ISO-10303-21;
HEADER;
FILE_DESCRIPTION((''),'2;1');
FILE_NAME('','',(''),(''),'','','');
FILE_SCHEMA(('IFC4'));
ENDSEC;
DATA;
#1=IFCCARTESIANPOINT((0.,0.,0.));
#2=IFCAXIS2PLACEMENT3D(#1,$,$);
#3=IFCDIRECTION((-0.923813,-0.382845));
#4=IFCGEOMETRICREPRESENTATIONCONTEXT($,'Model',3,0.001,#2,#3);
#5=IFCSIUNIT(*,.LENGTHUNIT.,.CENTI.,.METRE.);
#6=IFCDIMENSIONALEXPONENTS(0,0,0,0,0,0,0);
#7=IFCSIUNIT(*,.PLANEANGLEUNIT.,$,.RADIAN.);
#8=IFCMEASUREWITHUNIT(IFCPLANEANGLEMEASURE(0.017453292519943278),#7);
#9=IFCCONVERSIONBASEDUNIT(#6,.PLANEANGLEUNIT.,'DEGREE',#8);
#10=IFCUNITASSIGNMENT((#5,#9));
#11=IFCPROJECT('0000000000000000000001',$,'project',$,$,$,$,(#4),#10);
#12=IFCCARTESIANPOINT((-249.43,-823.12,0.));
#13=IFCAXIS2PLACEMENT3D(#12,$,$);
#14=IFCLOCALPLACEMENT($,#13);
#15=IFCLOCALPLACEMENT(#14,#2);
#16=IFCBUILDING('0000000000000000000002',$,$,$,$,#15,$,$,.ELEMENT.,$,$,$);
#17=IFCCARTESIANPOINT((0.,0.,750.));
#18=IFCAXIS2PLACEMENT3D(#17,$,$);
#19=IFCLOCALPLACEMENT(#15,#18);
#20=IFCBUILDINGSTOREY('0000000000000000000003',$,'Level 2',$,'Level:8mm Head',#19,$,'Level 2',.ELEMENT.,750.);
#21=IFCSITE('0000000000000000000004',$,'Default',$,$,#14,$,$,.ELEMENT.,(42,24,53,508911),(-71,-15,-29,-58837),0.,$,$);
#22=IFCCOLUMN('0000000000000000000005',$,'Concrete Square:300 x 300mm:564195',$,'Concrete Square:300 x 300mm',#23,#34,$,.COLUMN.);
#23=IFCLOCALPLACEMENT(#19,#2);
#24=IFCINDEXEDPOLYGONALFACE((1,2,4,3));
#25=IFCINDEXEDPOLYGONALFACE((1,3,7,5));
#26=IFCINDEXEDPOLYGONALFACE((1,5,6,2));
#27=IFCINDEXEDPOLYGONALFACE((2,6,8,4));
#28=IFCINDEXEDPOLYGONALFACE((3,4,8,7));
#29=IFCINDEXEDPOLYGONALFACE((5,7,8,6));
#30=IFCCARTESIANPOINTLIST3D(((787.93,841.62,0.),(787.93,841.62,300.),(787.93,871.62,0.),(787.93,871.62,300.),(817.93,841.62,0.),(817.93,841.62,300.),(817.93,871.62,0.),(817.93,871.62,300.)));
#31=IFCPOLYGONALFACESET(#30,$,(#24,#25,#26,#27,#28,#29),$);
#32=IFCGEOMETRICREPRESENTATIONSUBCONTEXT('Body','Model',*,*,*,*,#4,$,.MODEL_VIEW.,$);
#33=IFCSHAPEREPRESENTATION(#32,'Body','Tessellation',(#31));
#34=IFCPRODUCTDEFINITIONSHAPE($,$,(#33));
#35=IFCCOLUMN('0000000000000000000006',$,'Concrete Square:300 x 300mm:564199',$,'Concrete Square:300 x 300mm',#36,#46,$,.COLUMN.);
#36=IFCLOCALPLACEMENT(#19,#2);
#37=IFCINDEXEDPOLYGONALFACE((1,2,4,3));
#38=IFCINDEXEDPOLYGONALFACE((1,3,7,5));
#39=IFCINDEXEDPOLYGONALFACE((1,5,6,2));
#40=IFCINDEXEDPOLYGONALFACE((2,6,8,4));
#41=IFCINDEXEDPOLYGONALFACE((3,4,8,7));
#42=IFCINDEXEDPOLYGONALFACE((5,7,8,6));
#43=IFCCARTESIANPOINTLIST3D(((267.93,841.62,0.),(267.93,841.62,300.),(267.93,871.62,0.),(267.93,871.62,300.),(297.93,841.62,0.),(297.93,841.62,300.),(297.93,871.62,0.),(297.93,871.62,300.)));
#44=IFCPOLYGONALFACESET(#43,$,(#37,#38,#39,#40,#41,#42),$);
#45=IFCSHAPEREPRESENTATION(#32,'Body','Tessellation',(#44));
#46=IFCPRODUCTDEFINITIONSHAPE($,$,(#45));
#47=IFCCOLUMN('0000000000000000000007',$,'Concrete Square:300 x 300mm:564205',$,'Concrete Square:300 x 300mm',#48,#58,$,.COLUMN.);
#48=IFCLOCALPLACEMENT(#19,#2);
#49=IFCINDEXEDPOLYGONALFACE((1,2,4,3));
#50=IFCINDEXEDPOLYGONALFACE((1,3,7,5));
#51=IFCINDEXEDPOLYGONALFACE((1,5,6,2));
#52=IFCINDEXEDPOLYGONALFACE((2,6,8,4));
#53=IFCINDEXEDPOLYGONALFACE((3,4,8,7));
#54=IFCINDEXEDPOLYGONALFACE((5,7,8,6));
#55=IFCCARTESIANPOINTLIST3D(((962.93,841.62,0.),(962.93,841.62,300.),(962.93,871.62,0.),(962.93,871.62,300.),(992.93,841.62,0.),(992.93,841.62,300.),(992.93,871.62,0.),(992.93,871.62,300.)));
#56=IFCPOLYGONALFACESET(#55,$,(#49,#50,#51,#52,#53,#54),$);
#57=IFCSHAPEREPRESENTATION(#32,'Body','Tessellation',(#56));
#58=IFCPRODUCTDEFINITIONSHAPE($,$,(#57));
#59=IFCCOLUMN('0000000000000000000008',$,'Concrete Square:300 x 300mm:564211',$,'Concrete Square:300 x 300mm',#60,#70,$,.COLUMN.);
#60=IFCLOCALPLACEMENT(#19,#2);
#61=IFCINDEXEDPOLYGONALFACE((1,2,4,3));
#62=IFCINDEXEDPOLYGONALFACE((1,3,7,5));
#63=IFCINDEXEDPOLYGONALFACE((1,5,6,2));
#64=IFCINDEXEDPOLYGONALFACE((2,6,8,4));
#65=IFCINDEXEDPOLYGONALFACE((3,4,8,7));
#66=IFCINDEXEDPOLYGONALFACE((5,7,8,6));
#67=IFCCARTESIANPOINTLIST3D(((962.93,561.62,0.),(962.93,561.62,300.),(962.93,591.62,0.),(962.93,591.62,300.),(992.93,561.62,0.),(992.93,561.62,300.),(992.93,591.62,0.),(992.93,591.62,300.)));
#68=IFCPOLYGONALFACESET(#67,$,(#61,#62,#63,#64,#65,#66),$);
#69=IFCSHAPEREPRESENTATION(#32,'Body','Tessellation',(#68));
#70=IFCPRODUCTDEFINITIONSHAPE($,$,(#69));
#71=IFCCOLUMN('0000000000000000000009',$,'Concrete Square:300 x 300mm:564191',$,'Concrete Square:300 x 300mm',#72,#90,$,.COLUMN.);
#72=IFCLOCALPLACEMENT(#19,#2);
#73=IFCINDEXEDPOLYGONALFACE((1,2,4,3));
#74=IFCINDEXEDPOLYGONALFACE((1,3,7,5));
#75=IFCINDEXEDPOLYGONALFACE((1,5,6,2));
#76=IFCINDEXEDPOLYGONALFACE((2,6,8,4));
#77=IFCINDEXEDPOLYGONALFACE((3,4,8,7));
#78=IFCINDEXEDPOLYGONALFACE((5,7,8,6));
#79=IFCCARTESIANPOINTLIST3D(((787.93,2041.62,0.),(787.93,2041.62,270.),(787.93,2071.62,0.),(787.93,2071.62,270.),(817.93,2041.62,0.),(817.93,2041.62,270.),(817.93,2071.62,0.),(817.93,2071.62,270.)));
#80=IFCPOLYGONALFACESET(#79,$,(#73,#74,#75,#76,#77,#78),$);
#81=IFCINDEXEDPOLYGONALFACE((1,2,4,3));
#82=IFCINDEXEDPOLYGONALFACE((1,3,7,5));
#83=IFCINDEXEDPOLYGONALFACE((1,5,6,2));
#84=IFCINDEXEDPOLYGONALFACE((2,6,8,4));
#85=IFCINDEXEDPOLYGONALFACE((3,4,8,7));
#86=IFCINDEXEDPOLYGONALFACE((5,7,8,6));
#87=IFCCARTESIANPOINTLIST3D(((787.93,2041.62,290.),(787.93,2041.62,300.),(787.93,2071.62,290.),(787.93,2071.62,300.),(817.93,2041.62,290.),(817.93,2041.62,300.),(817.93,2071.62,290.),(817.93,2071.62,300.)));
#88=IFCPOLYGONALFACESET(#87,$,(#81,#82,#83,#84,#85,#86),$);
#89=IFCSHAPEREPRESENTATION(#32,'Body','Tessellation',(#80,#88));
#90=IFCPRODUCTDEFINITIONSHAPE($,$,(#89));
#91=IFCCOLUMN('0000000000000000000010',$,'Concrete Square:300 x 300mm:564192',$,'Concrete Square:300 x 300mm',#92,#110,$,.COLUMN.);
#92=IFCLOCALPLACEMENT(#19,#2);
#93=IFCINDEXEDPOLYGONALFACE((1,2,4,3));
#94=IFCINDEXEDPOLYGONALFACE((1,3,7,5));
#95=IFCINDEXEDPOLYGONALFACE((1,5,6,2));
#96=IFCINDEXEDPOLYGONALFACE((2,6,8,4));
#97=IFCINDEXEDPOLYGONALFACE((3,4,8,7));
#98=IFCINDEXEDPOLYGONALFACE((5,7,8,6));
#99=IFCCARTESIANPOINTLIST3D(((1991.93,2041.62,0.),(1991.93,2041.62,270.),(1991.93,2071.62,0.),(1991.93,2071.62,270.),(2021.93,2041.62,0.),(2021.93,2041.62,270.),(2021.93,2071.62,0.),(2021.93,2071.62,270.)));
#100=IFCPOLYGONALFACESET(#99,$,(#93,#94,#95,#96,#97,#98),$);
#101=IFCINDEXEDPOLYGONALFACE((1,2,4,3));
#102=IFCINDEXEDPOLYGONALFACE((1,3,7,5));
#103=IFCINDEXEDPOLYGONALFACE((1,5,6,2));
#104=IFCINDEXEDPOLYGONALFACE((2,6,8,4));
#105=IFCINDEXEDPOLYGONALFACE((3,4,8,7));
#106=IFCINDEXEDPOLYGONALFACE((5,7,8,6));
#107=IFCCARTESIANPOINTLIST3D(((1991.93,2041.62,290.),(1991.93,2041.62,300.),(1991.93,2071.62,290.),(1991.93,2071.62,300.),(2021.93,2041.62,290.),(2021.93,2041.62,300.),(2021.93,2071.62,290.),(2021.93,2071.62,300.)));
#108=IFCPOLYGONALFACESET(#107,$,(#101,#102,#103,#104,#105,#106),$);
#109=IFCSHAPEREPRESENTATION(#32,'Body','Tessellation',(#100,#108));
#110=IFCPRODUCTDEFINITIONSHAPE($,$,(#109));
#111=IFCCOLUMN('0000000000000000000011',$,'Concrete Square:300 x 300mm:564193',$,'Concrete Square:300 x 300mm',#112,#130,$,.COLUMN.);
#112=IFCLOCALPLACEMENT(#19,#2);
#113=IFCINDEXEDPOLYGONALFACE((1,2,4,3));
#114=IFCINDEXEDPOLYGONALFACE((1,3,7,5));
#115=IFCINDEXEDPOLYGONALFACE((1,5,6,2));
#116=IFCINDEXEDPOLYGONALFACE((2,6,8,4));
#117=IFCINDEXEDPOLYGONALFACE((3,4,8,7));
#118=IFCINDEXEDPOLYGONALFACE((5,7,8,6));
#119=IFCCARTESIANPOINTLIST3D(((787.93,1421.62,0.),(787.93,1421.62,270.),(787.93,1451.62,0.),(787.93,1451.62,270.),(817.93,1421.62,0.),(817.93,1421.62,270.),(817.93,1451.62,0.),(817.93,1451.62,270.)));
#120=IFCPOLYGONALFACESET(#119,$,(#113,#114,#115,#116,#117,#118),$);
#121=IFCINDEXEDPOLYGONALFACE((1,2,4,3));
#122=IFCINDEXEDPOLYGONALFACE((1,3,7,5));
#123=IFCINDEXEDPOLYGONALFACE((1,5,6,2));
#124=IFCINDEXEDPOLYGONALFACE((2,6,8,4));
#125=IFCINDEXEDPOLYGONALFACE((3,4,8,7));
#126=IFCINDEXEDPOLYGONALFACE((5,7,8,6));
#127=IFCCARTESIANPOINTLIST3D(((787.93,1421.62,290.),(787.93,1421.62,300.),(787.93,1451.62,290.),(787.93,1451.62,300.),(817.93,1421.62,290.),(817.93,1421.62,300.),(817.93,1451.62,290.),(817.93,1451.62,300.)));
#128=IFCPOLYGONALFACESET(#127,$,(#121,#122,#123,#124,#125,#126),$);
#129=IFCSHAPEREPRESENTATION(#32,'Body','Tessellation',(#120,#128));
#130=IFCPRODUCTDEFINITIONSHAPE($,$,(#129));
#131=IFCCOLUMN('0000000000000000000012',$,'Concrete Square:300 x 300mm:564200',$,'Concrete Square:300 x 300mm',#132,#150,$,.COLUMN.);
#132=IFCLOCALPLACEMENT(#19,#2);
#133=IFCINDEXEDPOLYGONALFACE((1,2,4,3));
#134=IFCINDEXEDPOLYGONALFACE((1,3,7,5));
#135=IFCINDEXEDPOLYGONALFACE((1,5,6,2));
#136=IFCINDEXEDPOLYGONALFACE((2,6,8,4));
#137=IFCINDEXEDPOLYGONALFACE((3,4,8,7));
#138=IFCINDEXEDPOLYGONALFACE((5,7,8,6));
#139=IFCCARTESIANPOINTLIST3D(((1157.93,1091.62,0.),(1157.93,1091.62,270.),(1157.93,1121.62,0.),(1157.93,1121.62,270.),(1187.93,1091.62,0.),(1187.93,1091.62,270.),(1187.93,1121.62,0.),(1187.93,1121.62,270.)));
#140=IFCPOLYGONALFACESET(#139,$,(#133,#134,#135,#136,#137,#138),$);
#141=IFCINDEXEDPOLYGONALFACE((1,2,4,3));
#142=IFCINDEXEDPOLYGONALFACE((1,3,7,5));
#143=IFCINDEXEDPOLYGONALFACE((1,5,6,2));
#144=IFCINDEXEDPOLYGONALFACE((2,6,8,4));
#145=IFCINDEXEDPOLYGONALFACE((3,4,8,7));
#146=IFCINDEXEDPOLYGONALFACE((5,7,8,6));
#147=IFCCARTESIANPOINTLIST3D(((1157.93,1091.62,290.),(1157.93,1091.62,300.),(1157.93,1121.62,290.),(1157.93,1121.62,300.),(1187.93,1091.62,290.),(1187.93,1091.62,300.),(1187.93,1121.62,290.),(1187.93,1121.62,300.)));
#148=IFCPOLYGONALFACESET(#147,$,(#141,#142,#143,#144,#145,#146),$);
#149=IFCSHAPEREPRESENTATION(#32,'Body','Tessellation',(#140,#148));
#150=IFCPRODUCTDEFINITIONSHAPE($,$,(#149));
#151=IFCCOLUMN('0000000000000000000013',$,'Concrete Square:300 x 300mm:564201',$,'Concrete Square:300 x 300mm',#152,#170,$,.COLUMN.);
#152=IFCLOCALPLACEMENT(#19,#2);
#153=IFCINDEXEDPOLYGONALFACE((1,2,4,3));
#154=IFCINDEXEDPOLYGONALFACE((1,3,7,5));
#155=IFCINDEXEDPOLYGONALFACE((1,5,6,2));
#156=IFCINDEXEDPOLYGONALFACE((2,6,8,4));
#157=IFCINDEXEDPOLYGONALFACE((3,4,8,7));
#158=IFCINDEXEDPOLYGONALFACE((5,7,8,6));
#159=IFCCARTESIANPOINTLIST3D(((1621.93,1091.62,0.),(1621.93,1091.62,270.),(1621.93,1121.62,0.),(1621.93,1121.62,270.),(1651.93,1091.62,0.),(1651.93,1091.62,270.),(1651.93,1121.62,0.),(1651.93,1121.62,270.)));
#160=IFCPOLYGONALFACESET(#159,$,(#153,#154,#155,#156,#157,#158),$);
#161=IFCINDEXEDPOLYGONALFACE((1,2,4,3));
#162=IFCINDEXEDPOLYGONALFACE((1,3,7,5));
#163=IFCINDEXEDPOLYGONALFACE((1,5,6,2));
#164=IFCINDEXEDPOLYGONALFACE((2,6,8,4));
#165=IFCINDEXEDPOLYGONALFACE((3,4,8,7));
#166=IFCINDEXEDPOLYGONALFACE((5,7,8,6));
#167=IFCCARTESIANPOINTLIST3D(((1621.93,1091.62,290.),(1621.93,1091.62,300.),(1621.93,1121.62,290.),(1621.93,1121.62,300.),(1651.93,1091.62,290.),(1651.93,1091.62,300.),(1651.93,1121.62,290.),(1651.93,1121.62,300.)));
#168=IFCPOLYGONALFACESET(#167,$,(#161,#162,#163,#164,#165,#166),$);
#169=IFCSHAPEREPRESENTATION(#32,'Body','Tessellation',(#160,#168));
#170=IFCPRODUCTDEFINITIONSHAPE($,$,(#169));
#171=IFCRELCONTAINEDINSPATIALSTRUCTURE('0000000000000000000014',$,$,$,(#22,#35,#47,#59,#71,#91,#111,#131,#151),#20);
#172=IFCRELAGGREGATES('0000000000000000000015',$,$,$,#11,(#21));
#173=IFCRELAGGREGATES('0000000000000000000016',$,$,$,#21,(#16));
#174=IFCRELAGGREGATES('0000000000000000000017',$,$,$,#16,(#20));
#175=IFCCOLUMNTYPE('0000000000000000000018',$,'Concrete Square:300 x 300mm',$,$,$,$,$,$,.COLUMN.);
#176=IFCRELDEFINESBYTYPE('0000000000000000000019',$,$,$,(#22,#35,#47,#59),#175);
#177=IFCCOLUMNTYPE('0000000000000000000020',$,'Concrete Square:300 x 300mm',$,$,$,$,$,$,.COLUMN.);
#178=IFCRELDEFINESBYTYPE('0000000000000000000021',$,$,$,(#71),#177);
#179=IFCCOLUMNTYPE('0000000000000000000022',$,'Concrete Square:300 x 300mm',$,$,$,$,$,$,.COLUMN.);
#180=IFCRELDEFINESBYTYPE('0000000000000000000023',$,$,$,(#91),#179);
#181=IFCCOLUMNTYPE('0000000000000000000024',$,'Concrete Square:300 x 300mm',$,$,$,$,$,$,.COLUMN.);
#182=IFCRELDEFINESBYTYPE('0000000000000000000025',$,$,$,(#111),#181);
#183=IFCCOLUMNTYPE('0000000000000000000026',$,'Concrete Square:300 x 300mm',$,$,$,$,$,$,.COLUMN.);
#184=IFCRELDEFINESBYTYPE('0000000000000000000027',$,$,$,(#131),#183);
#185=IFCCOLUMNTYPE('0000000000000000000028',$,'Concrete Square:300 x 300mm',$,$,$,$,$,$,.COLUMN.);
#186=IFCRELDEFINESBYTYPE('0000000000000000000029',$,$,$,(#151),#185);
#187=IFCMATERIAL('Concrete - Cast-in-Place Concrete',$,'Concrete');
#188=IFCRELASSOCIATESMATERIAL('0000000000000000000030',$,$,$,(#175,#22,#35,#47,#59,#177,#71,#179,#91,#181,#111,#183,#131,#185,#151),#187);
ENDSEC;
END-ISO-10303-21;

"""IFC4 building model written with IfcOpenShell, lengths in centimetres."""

from ifc_helpers import new_model, entity, si_unit, converted_unit, direction, frame, origin, place, context, subcontext, project, spatial, indexed_curve, outline, extrude, source, transform, mapped, material, type_object, type_shapes, element, save


model = new_model("IFC4")

# Units and contexts
model_context = context("Model", 3, precision=0.001, world=origin(), true_north=direction((-0.923813, -0.382845)))
body_context = subcontext(model_context, "Body", "Model", "MODEL_VIEW")
ifc_project = project(units=[si_unit("LENGTHUNIT", "METRE", prefix="CENTI"), converted_unit("PLANEANGLEUNIT", "DEGREE", entity("IfcPlaneAngleMeasure", 0.017453292519943278), si_unit("PLANEANGLEUNIT", "RADIAN"), dimensions=[0, 0, 0, 0, 0, 0, 0])], contexts=[model_context])

# Site, building, storey
site_placement = place(None, frame((-249.43, -823.12, 0.0)))
site = spatial("IfcSite", under=ifc_project, at=site_placement, Name="Default", CompositionType="ELEMENT", RefLatitude=(42, 24, 53, 508911), RefLongitude=(-71, -15, -29, -58837), RefElevation=0.0)
building_placement = place(site_placement, origin())
building = spatial("IfcBuilding", under=site, at=building_placement, CompositionType="ELEMENT")
storey_placement = place(building_placement, frame((0.0, 0.0, 750.0)))
storey = spatial("IfcBuildingStorey", under=building, at=storey_placement, Name="Level 2", ObjectType="Level:8mm Head", LongName="Level 2", CompositionType="ELEMENT", Elevation=750.0)

# Columns
ifc_material_1 = material(Name="Concrete - Cast-in-Place Concrete", Category="Concrete")
column_type_1 = type_object("IfcColumnType", Name="Concrete Square:300 x 300mm", PredefinedType="COLUMN", material=ifc_material_1)
shared_shape_1 = source(origin(), body_context, "Body", "SweptSolid", [
    extrude(outline(indexed_curve([(-15.0, -15.0), (15.0, -15.0), (15.0, 15.0), (-15.0, 15.0), (-15.0, -15.0)], self_intersect=False)), frame((0.0, 0.0, 750.0), z_axis=(0.0, 0.0, 1.0), x_axis=(-1.0, 0.0, 0.0)), (0.0, 0.0, 1.0), 300.0),
])
type_shapes(column_type_1, [shared_shape_1])
for number, where, name in (
    (1, (802.93, 856.62, -750.0), "Concrete Square:300 x 300mm:564195"),
    (2, (282.93, 856.62, -750.0), "Concrete Square:300 x 300mm:564199"),
    (3, (977.93, 856.62, -750.0), "Concrete Square:300 x 300mm:564205"),
    (4, (977.93, 576.62, -750.0), "Concrete Square:300 x 300mm:564211"),
):
    element("IfcColumn", number, at=place(storey_placement, frame(where)), inside=storey, type_object=column_type_1, material=ifc_material_1, Name=name, ObjectType="Concrete Square:300 x 300mm", PredefinedType="COLUMN", context=body_context, shape_type="MappedRepresentation", body=[
        mapped(shared_shape_1, transform((0.0, 0.0, 0.0), scale=1.0)),
    ])
column_type_2 = type_object("IfcColumnType", Name="Concrete Square:300 x 300mm", PredefinedType="COLUMN", material=ifc_material_1)
shared_shape_2 = source(origin(), body_context, "Body", "SweptSolid", [
    extrude(outline(indexed_curve([(-15.0, -15.0), (15.0, -15.0), (15.0, 15.0), (-15.0, 15.0), (-15.0, -15.0)], self_intersect=False)), frame((802.93, 2056.62, 750.0), z_axis=(0.0, 0.0, 1.0), x_axis=(-1.0, 0.0, 0.0)), (0.0, 0.0, 1.0), 270.0),
    extrude(outline(indexed_curve([(-15.0, -15.0), (15.0, -15.0), (15.0, 15.0), (-15.0, 15.0), (-15.0, -15.0)], self_intersect=False)), frame((802.93, 2056.62, 1040.0), z_axis=(0.0, 0.0, 1.0), x_axis=(-1.0, 0.0, 0.0)), (0.0, 0.0, 1.0), 10.0),
])
type_shapes(column_type_2, [shared_shape_2])
column_1_placement = place(storey_placement, frame((0.0, 0.0, -750.0)))
element("IfcColumn", 5, at=column_1_placement, inside=storey, type_object=column_type_2, material=ifc_material_1, Name="Concrete Square:300 x 300mm:564191", ObjectType="Concrete Square:300 x 300mm", PredefinedType="COLUMN", context=body_context, shape_type="MappedRepresentation", body=[
    mapped(shared_shape_2, transform((0.0, 0.0, 0.0), scale=1.0)),
])
column_type_3 = type_object("IfcColumnType", Name="Concrete Square:300 x 300mm", PredefinedType="COLUMN", material=ifc_material_1)
shared_shape_3 = source(origin(), body_context, "Body", "SweptSolid", [
    extrude(outline(indexed_curve([(-15.0, -15.0), (15.0, -15.0), (15.0, 15.0), (-15.0, 15.0), (-15.0, -15.0)], self_intersect=False)), frame((2006.93, 2056.62, 750.0), z_axis=(0.0, 0.0, 1.0), x_axis=(-1.0, 0.0, 0.0)), (0.0, 0.0, 1.0), 270.0),
    extrude(outline(indexed_curve([(-15.0, -15.0), (15.0, -15.0), (15.0, 15.0), (-15.0, 15.0), (-15.0, -15.0)], self_intersect=False)), frame((2006.93, 2056.62, 1040.0), z_axis=(0.0, 0.0, 1.0), x_axis=(-1.0, 0.0, 0.0)), (0.0, 0.0, 1.0), 10.0),
])
type_shapes(column_type_3, [shared_shape_3])
column_2_placement = place(storey_placement, frame((0.0, 0.0, -750.0)))
element("IfcColumn", 6, at=column_2_placement, inside=storey, type_object=column_type_3, material=ifc_material_1, Name="Concrete Square:300 x 300mm:564192", ObjectType="Concrete Square:300 x 300mm", PredefinedType="COLUMN", context=body_context, shape_type="MappedRepresentation", body=[
    mapped(shared_shape_3, transform((0.0, 0.0, 0.0), scale=1.0)),
])
column_type_4 = type_object("IfcColumnType", Name="Concrete Square:300 x 300mm", PredefinedType="COLUMN", material=ifc_material_1)
shared_shape_4 = source(origin(), body_context, "Body", "SweptSolid", [
    extrude(outline(indexed_curve([(-15.0, -15.0), (15.0, -15.0), (15.0, 15.0), (-15.0, 15.0), (-15.0, -15.0)], self_intersect=False)), frame((802.93, 1436.62, 750.0), z_axis=(0.0, 0.0, 1.0), x_axis=(-1.0, 0.0, 0.0)), (0.0, 0.0, 1.0), 270.0),
    extrude(outline(indexed_curve([(-15.0, -15.0), (15.0, -15.0), (15.0, 15.0), (-15.0, 15.0), (-15.0, -15.0)], self_intersect=False)), frame((802.93, 1436.62, 1040.0), z_axis=(0.0, 0.0, 1.0), x_axis=(-1.0, 0.0, 0.0)), (0.0, 0.0, 1.0), 10.0),
])
type_shapes(column_type_4, [shared_shape_4])
column_3_placement = place(storey_placement, frame((0.0, 0.0, -750.0)))
element("IfcColumn", 7, at=column_3_placement, inside=storey, type_object=column_type_4, material=ifc_material_1, Name="Concrete Square:300 x 300mm:564193", ObjectType="Concrete Square:300 x 300mm", PredefinedType="COLUMN", context=body_context, shape_type="MappedRepresentation", body=[
    mapped(shared_shape_4, transform((0.0, 0.0, 0.0), scale=1.0)),
])
column_type_5 = type_object("IfcColumnType", Name="Concrete Square:300 x 300mm", PredefinedType="COLUMN", material=ifc_material_1)
shared_shape_5 = source(origin(), body_context, "Body", "SweptSolid", [
    extrude(outline(indexed_curve([(-15.0, -15.0), (15.0, -15.0), (15.0, 15.0), (-15.0, 15.0), (-15.0, -15.0)], self_intersect=False)), frame((1172.93, 1106.62, 750.0), z_axis=(0.0, 0.0, 1.0), x_axis=(-1.0, 0.0, 0.0)), (0.0, 0.0, 1.0), 270.0),
    extrude(outline(indexed_curve([(-15.0, -15.0), (15.0, -15.0), (15.0, 15.0), (-15.0, 15.0), (-15.0, -15.0)], self_intersect=False)), frame((1172.93, 1106.62, 1040.0), z_axis=(0.0, 0.0, 1.0), x_axis=(-1.0, 0.0, 0.0)), (0.0, 0.0, 1.0), 10.0),
])
type_shapes(column_type_5, [shared_shape_5])
column_4_placement = place(storey_placement, frame((0.0, 0.0, -750.0)))
element("IfcColumn", 8, at=column_4_placement, inside=storey, type_object=column_type_5, material=ifc_material_1, Name="Concrete Square:300 x 300mm:564200", ObjectType="Concrete Square:300 x 300mm", PredefinedType="COLUMN", context=body_context, shape_type="MappedRepresentation", body=[
    mapped(shared_shape_5, transform((0.0, 0.0, 0.0), scale=1.0)),
])
column_type_6 = type_object("IfcColumnType", Name="Concrete Square:300 x 300mm", PredefinedType="COLUMN", material=ifc_material_1)
shared_shape_6 = source(origin(), body_context, "Body", "SweptSolid", [
    extrude(outline(indexed_curve([(-15.0, -15.0), (15.0, -15.0), (15.0, 15.0), (-15.0, 15.0), (-15.0, -15.0)], self_intersect=False)), frame((1636.93, 1106.62, 750.0), z_axis=(0.0, 0.0, 1.0), x_axis=(-1.0, 0.0, 0.0)), (0.0, 0.0, 1.0), 270.0),
    extrude(outline(indexed_curve([(-15.0, -15.0), (15.0, -15.0), (15.0, 15.0), (-15.0, 15.0), (-15.0, -15.0)], self_intersect=False)), frame((1636.93, 1106.62, 1040.0), z_axis=(0.0, 0.0, 1.0), x_axis=(-1.0, 0.0, 0.0)), (0.0, 0.0, 1.0), 10.0),
])
type_shapes(column_type_6, [shared_shape_6])
column_5_placement = place(storey_placement, frame((0.0, 0.0, -750.0)))
element("IfcColumn", 9, at=column_5_placement, inside=storey, type_object=column_type_6, material=ifc_material_1, Name="Concrete Square:300 x 300mm:564201", ObjectType="Concrete Square:300 x 300mm", PredefinedType="COLUMN", context=body_context, shape_type="MappedRepresentation", body=[
    mapped(shared_shape_6, transform((0.0, 0.0, 0.0), scale=1.0)),
])

save(model, "model.ifc")
